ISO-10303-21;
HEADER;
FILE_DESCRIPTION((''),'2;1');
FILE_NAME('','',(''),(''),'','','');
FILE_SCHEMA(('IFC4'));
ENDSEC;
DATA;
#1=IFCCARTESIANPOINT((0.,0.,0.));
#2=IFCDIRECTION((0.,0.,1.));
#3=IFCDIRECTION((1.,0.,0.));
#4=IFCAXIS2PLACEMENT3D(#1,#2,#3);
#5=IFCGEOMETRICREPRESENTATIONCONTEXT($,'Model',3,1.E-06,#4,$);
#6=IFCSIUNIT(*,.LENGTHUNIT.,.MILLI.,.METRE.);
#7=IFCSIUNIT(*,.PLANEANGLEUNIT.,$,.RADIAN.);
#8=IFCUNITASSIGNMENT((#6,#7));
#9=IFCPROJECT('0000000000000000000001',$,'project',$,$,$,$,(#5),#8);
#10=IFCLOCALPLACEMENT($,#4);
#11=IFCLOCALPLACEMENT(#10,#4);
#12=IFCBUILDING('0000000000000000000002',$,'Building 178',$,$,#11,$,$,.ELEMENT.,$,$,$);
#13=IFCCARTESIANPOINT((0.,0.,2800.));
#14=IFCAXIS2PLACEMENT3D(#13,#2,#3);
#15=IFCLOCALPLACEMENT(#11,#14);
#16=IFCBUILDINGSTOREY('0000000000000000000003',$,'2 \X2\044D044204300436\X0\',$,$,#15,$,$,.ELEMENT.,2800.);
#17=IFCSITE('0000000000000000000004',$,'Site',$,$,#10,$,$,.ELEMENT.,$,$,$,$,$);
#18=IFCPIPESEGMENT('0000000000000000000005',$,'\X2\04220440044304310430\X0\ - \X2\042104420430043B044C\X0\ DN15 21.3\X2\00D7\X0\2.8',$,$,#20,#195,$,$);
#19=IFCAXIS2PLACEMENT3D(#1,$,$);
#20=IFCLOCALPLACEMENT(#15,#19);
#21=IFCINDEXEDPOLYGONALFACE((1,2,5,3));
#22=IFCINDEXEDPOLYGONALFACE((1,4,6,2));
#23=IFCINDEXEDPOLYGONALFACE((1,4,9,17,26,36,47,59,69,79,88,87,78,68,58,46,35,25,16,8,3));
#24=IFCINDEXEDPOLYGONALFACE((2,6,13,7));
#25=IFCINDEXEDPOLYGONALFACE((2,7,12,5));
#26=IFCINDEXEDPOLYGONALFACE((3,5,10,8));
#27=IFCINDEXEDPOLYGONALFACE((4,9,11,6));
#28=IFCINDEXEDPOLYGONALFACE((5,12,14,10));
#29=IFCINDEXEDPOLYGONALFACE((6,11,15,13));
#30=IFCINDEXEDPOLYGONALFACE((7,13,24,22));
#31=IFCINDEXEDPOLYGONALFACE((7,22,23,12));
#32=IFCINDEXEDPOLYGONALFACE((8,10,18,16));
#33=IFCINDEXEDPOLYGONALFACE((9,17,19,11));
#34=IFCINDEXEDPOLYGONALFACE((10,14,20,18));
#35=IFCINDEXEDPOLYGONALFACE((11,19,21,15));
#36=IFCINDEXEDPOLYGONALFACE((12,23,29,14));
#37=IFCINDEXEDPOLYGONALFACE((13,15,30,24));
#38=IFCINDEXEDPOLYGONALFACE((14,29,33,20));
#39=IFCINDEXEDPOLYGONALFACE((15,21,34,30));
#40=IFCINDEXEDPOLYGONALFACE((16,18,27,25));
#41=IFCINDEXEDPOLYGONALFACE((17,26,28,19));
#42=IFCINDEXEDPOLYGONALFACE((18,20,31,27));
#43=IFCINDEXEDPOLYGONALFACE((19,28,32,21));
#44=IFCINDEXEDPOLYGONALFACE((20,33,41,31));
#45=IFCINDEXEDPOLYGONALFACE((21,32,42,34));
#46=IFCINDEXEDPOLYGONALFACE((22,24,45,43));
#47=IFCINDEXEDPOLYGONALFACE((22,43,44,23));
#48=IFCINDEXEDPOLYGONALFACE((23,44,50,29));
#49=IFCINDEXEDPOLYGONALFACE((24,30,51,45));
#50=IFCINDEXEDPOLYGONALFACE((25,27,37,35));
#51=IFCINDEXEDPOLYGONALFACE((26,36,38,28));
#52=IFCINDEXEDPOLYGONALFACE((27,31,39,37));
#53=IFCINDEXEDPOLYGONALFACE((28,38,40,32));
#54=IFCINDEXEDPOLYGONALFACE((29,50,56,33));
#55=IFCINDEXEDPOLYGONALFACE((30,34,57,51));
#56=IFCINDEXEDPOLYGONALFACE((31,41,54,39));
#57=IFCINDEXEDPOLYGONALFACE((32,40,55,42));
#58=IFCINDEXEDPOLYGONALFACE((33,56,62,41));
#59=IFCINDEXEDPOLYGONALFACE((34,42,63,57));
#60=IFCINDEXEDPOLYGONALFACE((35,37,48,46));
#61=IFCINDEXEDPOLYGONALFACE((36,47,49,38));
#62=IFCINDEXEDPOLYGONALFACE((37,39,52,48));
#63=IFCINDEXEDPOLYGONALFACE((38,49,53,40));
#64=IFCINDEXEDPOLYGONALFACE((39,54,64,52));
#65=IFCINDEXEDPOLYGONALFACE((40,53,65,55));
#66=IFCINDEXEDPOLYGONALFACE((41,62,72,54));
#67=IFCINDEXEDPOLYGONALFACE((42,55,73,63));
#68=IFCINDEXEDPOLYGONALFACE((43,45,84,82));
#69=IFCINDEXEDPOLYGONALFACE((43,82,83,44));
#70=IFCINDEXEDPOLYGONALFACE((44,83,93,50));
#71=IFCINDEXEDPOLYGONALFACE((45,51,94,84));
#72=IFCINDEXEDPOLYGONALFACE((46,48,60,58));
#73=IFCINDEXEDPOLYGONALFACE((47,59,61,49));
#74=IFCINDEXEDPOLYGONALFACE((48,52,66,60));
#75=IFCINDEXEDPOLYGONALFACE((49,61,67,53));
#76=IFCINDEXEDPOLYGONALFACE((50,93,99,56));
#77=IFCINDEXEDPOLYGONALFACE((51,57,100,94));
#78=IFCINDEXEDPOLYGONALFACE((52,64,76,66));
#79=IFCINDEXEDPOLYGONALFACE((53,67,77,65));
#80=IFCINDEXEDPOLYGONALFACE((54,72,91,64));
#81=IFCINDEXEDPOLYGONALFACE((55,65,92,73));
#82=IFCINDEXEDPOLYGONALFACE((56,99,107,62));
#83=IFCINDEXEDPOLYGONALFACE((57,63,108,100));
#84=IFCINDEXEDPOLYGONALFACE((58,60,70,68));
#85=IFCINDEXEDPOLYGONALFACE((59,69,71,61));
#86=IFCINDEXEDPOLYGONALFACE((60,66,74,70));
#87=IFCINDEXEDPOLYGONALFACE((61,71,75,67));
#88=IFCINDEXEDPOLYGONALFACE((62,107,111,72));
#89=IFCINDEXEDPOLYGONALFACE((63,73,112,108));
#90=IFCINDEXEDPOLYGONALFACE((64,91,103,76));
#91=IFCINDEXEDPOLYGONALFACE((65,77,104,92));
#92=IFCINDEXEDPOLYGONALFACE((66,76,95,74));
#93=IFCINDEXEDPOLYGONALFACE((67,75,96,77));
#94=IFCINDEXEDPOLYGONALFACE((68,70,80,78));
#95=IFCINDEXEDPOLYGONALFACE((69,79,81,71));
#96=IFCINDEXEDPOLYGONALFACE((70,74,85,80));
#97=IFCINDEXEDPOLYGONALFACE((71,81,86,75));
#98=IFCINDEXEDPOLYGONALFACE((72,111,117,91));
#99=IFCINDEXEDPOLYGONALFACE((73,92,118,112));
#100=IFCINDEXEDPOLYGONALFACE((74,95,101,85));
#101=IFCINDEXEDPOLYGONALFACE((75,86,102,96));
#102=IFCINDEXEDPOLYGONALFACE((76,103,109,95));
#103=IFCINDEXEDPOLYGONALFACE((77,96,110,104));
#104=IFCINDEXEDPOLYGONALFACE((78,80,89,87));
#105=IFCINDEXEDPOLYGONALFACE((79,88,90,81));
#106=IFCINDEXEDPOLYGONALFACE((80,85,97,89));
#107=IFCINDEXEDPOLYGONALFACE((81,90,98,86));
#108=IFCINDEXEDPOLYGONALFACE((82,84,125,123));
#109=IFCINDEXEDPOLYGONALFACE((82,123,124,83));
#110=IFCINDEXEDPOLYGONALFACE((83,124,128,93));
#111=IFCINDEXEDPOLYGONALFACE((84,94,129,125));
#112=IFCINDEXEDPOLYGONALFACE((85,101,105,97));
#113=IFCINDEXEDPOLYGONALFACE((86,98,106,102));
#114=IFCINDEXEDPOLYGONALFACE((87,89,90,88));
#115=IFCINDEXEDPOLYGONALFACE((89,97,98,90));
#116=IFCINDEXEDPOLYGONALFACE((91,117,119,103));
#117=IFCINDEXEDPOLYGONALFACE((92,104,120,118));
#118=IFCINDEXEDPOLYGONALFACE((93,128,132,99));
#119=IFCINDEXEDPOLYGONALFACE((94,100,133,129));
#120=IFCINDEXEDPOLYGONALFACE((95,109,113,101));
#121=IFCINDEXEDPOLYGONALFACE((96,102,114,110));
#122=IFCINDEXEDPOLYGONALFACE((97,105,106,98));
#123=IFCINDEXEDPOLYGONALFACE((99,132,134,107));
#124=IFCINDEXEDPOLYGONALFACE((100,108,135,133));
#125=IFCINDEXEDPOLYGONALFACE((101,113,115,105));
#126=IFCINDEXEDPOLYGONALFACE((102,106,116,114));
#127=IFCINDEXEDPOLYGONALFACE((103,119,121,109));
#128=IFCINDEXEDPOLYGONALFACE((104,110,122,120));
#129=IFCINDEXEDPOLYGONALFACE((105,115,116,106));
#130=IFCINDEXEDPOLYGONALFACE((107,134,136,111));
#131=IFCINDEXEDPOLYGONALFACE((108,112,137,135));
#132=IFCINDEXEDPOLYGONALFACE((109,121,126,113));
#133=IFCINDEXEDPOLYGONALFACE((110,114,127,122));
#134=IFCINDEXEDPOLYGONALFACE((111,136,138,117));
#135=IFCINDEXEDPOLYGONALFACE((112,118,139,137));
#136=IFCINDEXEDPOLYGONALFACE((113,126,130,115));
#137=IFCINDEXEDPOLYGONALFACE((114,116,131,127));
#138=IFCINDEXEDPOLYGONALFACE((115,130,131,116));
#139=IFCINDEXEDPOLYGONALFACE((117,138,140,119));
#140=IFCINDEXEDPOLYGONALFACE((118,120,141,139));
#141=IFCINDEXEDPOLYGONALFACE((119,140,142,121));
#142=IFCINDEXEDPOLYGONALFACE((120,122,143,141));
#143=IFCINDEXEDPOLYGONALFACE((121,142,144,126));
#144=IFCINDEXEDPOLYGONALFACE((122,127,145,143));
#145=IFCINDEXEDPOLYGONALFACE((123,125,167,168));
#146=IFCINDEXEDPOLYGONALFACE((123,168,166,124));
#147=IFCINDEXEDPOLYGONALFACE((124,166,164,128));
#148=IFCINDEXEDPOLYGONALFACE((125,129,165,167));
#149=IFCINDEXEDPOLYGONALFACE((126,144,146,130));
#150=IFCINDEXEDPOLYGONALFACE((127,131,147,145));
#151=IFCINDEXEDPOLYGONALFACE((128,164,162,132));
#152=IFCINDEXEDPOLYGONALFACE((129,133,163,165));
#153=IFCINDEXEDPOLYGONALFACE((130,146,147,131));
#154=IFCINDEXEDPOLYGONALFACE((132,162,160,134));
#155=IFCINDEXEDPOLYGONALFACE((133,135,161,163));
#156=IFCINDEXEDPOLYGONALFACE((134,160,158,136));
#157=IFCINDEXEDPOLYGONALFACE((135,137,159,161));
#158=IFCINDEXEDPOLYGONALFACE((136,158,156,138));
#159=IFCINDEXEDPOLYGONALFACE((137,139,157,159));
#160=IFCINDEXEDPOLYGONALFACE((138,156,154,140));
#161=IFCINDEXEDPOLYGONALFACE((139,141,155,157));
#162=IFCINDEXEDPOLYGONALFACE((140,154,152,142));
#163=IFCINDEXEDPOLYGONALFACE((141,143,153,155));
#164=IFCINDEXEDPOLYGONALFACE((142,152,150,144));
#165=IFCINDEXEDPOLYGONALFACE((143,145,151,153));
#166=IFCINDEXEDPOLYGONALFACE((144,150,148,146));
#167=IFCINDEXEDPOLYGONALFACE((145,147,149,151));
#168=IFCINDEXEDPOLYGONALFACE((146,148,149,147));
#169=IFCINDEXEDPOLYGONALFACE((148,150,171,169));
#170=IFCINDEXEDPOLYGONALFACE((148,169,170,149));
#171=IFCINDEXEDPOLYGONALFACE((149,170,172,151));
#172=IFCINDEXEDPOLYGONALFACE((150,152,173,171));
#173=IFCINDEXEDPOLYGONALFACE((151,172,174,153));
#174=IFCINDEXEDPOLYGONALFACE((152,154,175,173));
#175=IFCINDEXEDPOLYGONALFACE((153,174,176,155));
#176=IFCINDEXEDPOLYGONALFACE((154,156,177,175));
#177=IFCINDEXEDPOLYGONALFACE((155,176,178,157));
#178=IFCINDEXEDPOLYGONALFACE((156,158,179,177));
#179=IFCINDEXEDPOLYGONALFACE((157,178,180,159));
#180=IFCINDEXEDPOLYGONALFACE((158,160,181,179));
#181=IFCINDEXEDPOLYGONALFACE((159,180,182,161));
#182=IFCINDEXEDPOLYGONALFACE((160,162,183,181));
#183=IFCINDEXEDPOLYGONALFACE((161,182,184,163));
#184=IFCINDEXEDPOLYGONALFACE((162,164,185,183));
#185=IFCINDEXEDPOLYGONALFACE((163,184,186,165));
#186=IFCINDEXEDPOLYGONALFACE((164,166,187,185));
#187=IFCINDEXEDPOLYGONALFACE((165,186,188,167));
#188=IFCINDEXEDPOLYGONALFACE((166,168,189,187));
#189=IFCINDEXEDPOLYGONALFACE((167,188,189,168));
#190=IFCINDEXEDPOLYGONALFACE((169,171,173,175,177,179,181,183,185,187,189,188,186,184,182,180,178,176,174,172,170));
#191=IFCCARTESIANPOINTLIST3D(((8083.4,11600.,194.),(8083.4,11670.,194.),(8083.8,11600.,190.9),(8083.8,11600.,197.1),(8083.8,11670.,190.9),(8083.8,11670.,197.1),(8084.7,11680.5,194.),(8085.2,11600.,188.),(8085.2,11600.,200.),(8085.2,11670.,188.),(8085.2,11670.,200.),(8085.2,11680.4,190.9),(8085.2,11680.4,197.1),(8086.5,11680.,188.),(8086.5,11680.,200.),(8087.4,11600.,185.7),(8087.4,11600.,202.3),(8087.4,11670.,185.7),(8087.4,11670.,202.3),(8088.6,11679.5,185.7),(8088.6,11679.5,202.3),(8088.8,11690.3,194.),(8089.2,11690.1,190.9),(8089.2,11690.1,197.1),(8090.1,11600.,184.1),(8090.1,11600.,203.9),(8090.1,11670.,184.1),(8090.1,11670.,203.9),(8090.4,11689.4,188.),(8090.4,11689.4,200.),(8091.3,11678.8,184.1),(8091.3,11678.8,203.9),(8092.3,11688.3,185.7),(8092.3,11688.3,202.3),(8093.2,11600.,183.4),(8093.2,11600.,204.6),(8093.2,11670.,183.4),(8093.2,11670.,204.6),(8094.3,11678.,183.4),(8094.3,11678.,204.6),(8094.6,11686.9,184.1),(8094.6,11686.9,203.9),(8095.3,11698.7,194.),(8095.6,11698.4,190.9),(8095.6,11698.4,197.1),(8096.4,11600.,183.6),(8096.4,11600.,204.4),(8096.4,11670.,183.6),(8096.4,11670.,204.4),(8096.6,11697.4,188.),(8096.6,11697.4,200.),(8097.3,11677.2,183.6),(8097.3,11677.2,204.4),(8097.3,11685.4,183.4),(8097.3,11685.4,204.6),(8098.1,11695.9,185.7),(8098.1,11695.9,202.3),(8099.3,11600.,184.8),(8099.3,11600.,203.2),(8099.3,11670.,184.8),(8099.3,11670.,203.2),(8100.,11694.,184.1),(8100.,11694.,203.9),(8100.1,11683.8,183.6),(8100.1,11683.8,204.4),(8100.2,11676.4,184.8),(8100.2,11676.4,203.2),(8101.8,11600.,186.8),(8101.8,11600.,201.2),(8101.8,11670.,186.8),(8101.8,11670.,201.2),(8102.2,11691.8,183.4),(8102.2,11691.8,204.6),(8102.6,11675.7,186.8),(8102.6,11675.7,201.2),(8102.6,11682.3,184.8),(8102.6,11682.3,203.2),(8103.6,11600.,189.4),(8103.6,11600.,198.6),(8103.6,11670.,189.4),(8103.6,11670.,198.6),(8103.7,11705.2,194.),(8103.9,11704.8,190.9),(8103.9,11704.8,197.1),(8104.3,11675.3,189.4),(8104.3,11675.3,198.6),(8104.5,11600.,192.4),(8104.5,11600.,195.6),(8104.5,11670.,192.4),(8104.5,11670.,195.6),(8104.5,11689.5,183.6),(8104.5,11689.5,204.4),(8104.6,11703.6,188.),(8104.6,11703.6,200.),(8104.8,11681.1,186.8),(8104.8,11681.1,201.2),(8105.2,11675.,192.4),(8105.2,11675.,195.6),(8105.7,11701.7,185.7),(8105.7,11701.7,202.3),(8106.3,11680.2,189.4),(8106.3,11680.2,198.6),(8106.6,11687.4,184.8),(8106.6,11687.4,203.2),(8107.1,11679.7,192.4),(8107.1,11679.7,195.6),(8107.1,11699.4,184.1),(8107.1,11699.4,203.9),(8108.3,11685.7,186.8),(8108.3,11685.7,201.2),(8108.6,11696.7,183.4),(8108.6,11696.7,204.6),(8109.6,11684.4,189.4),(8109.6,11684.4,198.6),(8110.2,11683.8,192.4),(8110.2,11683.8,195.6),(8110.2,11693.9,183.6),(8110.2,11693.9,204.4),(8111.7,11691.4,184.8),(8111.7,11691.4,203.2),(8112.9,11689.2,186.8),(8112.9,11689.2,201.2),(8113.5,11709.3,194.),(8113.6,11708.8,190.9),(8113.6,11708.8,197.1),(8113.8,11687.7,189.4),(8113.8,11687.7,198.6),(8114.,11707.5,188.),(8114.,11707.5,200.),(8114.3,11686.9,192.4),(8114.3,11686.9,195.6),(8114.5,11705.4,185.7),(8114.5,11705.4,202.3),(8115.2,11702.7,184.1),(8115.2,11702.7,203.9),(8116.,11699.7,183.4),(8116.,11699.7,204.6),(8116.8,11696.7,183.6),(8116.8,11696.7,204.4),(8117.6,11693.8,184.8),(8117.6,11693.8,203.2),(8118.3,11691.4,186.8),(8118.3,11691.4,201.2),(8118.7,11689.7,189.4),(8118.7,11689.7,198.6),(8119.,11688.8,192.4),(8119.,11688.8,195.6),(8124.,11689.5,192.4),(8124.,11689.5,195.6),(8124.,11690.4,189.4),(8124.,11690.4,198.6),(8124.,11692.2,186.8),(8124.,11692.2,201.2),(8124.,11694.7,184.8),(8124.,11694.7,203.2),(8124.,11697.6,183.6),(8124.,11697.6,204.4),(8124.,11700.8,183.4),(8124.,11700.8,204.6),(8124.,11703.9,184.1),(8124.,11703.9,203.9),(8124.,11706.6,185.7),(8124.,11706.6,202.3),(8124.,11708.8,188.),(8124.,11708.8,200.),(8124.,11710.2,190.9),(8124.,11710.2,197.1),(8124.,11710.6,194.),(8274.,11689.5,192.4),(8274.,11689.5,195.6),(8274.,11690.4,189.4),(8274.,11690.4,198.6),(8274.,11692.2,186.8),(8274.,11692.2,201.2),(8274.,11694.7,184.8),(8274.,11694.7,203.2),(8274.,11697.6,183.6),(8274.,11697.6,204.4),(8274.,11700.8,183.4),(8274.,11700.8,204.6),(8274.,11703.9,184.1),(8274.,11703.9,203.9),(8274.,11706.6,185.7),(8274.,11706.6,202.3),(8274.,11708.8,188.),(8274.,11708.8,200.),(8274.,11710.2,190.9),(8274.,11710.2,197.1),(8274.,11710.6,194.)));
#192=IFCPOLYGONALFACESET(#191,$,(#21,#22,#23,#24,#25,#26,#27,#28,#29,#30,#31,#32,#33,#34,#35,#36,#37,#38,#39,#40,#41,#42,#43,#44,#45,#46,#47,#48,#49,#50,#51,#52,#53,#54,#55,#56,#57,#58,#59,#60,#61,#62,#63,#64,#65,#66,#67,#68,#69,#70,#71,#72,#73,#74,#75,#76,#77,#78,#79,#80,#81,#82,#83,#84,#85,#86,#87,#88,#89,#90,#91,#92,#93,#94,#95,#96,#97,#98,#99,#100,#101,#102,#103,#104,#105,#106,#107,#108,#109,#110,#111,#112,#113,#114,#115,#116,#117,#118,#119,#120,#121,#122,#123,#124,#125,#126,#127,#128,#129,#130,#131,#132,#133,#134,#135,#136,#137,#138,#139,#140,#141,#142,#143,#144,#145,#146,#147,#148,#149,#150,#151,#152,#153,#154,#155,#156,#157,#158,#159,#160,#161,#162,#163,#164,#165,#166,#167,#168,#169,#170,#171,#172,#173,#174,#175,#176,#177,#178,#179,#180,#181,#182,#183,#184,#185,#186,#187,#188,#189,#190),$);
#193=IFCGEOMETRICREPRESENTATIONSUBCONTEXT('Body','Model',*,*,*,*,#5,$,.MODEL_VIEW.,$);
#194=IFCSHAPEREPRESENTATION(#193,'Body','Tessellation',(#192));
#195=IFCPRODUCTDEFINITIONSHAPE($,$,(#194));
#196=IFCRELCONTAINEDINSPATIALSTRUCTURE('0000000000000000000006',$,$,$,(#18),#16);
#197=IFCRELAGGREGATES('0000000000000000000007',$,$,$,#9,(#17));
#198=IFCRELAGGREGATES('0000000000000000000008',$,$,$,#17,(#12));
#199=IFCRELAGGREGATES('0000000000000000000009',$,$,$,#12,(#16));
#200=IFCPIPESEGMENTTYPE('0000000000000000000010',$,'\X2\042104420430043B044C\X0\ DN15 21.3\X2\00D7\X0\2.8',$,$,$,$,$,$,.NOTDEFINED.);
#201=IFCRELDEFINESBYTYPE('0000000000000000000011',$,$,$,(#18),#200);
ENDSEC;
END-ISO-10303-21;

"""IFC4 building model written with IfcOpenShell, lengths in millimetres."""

from ifc_helpers import new_model, entity, si_unit, frame, origin_with_axes, place, context, subcontext, project, spatial, source, transform, mapped, type_object, element, save


model = new_model("IFC4")

# Units and contexts
model_context = context("Model", 3, precision=1e-06, world=origin_with_axes())
body_context = subcontext(model_context, "Body", "Model", "MODEL_VIEW")
ifc_project = project(units=[si_unit("LENGTHUNIT", "METRE", prefix="MILLI"), si_unit("PLANEANGLEUNIT", "RADIAN")], contexts=[model_context])

# Site, building, storey
site_placement = place(None, origin_with_axes())
site = spatial("IfcSite", under=ifc_project, at=site_placement, Name="Site", CompositionType="ELEMENT")
building_placement = place(site_placement, origin_with_axes())
building = spatial("IfcBuilding", under=site, at=building_placement, Name="Building 178", CompositionType="ELEMENT")
storey_placement = place(building_placement, frame((0.0, 0.0, 2800.0), z_axis=(0.0, 0.0, 1.0), x_axis=(1.0, 0.0, 0.0)))
storey = spatial("IfcBuildingStorey", under=building, at=storey_placement, Name="2 этаж", CompositionType="ELEMENT", Elevation=2800.0)

# Pipe segment
pipe_segment_type = type_object("IfcPipeSegmentType", Name="Сталь DN15 21.3×2.8", PredefinedType="NOTDEFINED")
shared_shape_1 = source(origin_with_axes(), body_context, "Body", "AdvancedSweptSolid", [
    entity("IfcSweptDiskSolid", entity("IfcIndexedPolyCurve", entity("IfcCartesianPointList3D", [[0.0, 0.0, 0.0], [0.0, 0.0, -70.0], [8.8, 0.0, -91.2], [30.0, 0.0, -100.0], [180.0, 0.0, -100.0]]), [entity("IfcLineIndex", [1, 2]), entity("IfcArcIndex", [2, 3, 4]), entity("IfcLineIndex", [4, 5])]), 10.7),
])
for number, where, z_axis, x_axis, name in (
    (1, (8094.0, 11600.0, 194.0), (0.0, -1.0, 0.0), (1.0, 0.0, 0.0), "Труба - Сталь DN15 21.3×2.8"),
):
    element("IfcPipeSegment", number, at=place(storey_placement, frame(where, z_axis=z_axis, x_axis=x_axis)), inside=storey, type_object=pipe_segment_type, Name=name, context=body_context, shape_type="MappedRepresentation", body=[
        mapped(shared_shape_1, transform((0.0, 0.0, 0.0), x_axis=(1.0, 0.0, 0.0), y_axis=(0.0, 1.0, 0.0), z_axis=(0.0, 0.0, 1.0), scale=1.0)),
    ])

save(model, "model.ifc")
